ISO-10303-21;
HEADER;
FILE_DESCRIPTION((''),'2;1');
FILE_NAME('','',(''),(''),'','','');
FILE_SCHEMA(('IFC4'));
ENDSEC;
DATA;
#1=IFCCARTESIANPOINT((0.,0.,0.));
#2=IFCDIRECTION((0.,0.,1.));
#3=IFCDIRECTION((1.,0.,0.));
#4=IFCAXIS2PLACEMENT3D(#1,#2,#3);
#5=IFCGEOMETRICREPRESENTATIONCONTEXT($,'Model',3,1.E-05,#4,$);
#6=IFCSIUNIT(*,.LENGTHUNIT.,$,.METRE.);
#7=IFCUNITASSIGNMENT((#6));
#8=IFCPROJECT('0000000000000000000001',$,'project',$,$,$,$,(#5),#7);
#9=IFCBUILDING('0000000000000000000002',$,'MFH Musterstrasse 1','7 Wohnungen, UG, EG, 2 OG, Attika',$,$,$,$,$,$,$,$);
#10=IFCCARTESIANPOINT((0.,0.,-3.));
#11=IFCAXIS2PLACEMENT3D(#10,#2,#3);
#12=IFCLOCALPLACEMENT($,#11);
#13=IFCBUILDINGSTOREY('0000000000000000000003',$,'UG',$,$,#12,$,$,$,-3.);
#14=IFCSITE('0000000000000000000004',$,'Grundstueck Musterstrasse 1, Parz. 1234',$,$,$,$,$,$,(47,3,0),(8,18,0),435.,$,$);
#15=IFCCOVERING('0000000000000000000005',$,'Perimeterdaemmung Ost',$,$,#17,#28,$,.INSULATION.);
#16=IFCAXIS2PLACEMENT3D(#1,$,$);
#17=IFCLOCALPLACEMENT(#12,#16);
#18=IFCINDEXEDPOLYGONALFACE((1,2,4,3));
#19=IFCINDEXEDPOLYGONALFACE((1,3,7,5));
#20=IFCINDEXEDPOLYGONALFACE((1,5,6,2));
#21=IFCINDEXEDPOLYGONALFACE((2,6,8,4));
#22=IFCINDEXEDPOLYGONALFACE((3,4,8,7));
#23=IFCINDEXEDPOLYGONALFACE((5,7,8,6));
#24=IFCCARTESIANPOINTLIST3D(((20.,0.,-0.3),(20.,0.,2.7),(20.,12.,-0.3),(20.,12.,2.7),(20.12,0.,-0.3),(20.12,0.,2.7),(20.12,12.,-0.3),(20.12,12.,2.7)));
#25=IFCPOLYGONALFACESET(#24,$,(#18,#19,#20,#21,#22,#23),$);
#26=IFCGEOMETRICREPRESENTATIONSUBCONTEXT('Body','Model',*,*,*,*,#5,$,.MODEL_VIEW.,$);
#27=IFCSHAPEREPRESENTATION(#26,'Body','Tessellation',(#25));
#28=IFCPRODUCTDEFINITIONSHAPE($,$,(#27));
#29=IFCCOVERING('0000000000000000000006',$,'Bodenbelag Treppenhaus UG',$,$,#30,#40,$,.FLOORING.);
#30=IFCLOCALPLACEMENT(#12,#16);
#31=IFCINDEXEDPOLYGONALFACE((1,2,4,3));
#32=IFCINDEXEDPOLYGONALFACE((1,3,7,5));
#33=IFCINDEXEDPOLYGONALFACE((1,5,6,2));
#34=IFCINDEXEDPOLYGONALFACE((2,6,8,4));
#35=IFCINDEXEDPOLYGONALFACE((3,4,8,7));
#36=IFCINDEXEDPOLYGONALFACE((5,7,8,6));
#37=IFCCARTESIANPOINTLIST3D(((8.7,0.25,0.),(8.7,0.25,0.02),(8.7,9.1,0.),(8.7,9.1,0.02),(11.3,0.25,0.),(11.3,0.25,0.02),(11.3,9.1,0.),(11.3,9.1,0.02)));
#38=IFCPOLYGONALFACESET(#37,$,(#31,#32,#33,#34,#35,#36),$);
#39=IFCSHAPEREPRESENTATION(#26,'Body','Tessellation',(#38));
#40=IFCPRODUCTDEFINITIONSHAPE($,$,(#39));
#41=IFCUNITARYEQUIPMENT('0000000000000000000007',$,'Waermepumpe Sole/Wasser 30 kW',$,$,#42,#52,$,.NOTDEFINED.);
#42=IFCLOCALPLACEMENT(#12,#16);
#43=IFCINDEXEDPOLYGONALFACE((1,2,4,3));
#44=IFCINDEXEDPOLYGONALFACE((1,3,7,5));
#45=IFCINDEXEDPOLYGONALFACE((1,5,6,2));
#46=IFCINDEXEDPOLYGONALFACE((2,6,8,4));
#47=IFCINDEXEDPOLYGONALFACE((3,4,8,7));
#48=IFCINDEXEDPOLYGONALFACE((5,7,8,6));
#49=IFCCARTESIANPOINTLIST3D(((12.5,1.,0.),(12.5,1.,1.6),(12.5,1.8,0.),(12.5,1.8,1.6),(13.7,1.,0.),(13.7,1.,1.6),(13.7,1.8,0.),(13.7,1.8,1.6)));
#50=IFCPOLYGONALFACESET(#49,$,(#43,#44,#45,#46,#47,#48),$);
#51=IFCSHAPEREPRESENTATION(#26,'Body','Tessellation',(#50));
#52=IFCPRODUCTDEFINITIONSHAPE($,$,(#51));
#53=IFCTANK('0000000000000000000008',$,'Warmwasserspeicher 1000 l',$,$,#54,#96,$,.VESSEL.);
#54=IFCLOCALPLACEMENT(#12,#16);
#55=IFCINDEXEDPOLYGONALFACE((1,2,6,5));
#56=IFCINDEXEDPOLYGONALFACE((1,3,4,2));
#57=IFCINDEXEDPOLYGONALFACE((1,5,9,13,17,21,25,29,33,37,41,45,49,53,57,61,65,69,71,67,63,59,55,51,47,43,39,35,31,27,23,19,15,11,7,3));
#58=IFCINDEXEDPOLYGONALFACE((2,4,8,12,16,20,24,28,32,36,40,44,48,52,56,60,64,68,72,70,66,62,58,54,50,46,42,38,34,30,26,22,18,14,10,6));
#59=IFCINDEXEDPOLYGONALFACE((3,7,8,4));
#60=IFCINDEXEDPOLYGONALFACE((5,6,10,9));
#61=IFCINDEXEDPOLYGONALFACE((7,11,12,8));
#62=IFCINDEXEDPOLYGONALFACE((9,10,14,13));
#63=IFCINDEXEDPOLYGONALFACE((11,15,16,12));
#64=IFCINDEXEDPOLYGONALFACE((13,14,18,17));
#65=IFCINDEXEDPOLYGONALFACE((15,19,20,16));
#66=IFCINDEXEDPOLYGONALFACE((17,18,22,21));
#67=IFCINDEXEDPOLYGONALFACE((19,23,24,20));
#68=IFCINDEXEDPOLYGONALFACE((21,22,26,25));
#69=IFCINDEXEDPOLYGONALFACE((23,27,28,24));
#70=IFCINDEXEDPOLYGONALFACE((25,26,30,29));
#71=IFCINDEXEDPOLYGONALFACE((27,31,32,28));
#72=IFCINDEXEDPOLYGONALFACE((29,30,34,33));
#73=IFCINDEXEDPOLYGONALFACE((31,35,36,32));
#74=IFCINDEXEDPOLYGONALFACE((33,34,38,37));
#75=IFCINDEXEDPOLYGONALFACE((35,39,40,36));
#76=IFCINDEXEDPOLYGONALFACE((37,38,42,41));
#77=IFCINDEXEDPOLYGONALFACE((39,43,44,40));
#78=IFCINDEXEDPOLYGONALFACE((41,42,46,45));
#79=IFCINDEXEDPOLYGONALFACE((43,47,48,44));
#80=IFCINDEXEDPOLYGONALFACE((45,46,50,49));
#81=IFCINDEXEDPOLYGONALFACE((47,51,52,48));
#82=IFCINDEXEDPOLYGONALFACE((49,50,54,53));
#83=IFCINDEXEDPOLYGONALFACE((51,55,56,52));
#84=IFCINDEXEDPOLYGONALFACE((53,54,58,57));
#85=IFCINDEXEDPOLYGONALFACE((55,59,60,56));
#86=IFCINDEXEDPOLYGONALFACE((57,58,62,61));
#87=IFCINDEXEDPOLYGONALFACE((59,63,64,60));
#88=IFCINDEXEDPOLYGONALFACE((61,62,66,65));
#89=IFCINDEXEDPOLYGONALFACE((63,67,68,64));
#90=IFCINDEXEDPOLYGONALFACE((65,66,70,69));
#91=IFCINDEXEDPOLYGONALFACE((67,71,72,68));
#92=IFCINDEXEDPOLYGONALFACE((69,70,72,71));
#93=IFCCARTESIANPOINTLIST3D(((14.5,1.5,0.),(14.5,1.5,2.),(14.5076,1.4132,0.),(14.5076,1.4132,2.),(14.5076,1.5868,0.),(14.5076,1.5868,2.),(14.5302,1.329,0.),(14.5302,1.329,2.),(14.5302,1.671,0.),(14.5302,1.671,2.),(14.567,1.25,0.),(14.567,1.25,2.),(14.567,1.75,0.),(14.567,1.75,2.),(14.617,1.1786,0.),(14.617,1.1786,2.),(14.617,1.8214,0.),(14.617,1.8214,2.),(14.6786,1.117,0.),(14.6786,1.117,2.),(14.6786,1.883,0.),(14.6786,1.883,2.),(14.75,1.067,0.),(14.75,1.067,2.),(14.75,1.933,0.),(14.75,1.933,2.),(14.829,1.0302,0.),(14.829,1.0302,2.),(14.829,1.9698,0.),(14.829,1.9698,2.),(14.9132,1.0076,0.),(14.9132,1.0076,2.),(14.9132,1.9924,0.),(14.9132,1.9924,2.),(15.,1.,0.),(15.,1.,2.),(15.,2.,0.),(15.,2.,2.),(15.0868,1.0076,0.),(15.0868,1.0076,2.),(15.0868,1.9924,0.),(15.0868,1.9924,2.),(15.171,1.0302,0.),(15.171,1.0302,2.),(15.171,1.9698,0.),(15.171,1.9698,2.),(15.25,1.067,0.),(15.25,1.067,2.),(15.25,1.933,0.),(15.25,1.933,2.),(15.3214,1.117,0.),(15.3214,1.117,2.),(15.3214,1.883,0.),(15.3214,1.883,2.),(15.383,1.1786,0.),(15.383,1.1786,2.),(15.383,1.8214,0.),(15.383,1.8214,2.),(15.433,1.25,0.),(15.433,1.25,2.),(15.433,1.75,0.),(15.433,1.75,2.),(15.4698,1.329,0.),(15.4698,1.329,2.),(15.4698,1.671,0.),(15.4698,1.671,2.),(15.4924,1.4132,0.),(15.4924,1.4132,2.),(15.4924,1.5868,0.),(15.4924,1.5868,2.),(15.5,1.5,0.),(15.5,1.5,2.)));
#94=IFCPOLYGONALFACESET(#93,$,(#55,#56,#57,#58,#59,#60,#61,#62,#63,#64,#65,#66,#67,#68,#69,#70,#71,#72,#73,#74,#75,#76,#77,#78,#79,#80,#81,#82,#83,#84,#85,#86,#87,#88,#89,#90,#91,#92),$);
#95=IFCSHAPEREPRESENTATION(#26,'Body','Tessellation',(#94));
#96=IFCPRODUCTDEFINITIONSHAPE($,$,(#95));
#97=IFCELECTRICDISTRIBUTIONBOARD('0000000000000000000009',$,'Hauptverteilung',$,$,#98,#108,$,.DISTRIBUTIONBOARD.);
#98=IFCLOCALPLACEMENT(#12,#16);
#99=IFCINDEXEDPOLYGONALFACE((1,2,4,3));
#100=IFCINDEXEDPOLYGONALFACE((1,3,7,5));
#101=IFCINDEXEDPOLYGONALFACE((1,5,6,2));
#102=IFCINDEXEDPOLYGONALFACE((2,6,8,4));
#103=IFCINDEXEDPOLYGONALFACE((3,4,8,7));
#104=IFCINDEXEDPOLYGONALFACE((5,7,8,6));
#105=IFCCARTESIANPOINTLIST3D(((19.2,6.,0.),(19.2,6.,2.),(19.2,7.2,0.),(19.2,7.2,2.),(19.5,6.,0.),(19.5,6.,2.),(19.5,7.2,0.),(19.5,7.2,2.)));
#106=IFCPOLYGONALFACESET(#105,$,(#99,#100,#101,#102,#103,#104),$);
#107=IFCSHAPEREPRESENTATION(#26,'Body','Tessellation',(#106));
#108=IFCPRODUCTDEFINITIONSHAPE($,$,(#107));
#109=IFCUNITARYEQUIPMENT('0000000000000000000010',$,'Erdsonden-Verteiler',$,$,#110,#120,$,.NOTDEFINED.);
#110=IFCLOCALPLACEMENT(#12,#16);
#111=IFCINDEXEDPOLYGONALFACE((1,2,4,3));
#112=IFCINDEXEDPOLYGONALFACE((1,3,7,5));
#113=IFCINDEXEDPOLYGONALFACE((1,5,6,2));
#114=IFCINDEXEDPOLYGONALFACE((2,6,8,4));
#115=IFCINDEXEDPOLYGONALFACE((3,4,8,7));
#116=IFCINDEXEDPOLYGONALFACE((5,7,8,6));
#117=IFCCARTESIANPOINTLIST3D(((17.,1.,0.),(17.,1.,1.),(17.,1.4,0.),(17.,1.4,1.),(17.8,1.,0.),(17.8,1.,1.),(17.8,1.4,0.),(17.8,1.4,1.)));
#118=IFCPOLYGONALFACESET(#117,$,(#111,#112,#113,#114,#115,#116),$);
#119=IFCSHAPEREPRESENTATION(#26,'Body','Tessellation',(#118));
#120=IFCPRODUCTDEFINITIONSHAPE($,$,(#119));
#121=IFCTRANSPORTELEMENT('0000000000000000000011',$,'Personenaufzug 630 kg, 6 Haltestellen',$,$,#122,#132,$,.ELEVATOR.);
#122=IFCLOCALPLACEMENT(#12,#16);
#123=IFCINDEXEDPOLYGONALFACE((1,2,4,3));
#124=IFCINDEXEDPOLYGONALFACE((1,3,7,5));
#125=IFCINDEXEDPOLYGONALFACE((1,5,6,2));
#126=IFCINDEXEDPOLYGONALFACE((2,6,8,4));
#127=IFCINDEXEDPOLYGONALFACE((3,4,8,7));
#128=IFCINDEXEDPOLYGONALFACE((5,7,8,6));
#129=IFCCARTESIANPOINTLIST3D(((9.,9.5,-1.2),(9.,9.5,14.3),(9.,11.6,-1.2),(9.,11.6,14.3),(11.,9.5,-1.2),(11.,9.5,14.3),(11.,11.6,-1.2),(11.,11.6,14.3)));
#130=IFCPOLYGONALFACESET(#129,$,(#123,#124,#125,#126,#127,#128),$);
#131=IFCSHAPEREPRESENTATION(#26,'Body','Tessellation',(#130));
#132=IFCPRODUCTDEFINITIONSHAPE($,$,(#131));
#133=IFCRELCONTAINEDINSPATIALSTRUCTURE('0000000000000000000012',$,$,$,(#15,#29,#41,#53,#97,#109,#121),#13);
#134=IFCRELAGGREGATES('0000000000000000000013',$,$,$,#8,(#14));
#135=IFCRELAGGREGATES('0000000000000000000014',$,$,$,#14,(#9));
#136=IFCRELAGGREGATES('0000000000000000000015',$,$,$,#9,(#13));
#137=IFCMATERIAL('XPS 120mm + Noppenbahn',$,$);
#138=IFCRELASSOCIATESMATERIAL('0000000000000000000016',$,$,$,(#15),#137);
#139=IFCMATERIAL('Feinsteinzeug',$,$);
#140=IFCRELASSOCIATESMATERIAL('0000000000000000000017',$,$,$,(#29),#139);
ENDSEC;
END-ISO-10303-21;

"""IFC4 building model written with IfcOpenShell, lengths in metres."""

from ifc_helpers import new_model, si_unit, frame, frame_2d, origin_with_axes, origin_2d, place, context, subcontext, project, spatial, rectangle, circle, extrude, material, element, save


model = new_model("IFC4")

# Units and contexts
model_context = context("Model", 3, precision=1e-05, world=origin_with_axes())
body_context = subcontext(model_context, "Body", "Model", "MODEL_VIEW")
ifc_project = project(units=[si_unit("LENGTHUNIT", "METRE")], contexts=[model_context])

# Site, building, storey
site = spatial("IfcSite", under=ifc_project, Name="Grundstueck Musterstrasse 1, Parz. 1234", RefLatitude=(47, 3, 0), RefLongitude=(8, 18, 0), RefElevation=435.0)
building = spatial("IfcBuilding", under=site, Name="MFH Musterstrasse 1", Description="7 Wohnungen, UG, EG, 2 OG, Attika")
storey_placement = place(None, frame((0.0, 0.0, -3.0), z_axis=(0.0, 0.0, 1.0), x_axis=(1.0, 0.0, 0.0)))
storey = spatial("IfcBuildingStorey", under=building, at=storey_placement, Name="UG", Elevation=-3.0)

# Coverings
ifc_material_1 = material(Name="XPS 120mm + Noppenbahn")
for number, where, z_axis, x_axis, name in (
    (1, (20.0, 0.0, -0.3), (0.0, 0.0, 1.0), (1.0, 0.0, 0.0), "Perimeterdaemmung Ost"),
):
    element("IfcCovering", number, at=place(storey_placement, frame(where, z_axis=z_axis, x_axis=x_axis)), inside=storey, material=ifc_material_1, Name=name, PredefinedType="INSULATION", context=body_context, shape_type="SweptSolid", body=[
        extrude(rectangle(XDim=0.12, YDim=12.0, at=frame_2d((0.06, 6.0))), origin_with_axes(), (0.0, 0.0, 1.0), 3.0),
    ])
ifc_material_2 = material(Name="Feinsteinzeug")
covering_placement = place(storey_placement, frame((8.7, 0.25, 0.0), z_axis=(0.0, 0.0, 1.0), x_axis=(1.0, 0.0, 0.0)))
element("IfcCovering", 2, at=covering_placement, inside=storey, material=ifc_material_2, Name="Bodenbelag Treppenhaus UG", PredefinedType="FLOORING", context=body_context, shape_type="SweptSolid", body=[
    extrude(rectangle(XDim=2.6, YDim=8.85, at=frame_2d((1.3, 4.425))), origin_with_axes(), (0.0, 0.0, 1.0), 0.02),
])

# Unitary equipment
unitary_equipment_1_placement = place(storey_placement, frame((12.5, 1.0, 0.0), z_axis=(0.0, 0.0, 1.0), x_axis=(1.0, 0.0, 0.0)))
element("IfcUnitaryEquipment", 3, at=unitary_equipment_1_placement, inside=storey, Name="Waermepumpe Sole/Wasser 30 kW", PredefinedType="NOTDEFINED", context=body_context, shape_type="SweptSolid", body=[
    extrude(rectangle(XDim=1.2, YDim=0.8, at=frame_2d((0.6, 0.4))), origin_with_axes(), (0.0, 0.0, 1.0), 1.6),
])

# Tank
tank_placement = place(storey_placement, frame((15.0, 1.5, 0.0), z_axis=(0.0, 0.0, 1.0), x_axis=(1.0, 0.0, 0.0)))
element("IfcTank", 4, at=tank_placement, inside=storey, Name="Warmwasserspeicher 1000 l", PredefinedType="VESSEL", context=body_context, shape_type="SweptSolid", body=[
    extrude(circle(Radius=0.5, at=origin_2d()), origin_with_axes(), (0.0, 0.0, 1.0), 2.0),
])

# Electric distribution board
electric_distribution_board_placement = place(storey_placement, frame((19.2, 6.0, 0.0), z_axis=(0.0, 0.0, 1.0), x_axis=(1.0, 0.0, 0.0)))
element("IfcElectricDistributionBoard", 5, at=electric_distribution_board_placement, inside=storey, Name="Hauptverteilung", PredefinedType="DISTRIBUTIONBOARD", context=body_context, shape_type="SweptSolid", body=[
    extrude(rectangle(XDim=0.3, YDim=1.2, at=frame_2d((0.15, 0.6))), origin_with_axes(), (0.0, 0.0, 1.0), 2.0),
])

# Unitary equipment
unitary_equipment_2_placement = place(storey_placement, frame((17.0, 1.0, 0.0), z_axis=(0.0, 0.0, 1.0), x_axis=(1.0, 0.0, 0.0)))
element("IfcUnitaryEquipment", 6, at=unitary_equipment_2_placement, inside=storey, Name="Erdsonden-Verteiler", PredefinedType="NOTDEFINED", context=body_context, shape_type="SweptSolid", body=[
    extrude(rectangle(XDim=0.8, YDim=0.4, at=frame_2d((0.4, 0.2))), origin_with_axes(), (0.0, 0.0, 1.0), 1.0),
])

# Transport element
transport_element_placement = place(storey_placement, frame((9.0, 9.5, -1.2), z_axis=(0.0, 0.0, 1.0), x_axis=(1.0, 0.0, 0.0)))
element("IfcTransportElement", 7, at=transport_element_placement, inside=storey, Name="Personenaufzug 630 kg, 6 Haltestellen", PredefinedType="ELEVATOR", context=body_context, shape_type="SweptSolid", body=[
    extrude(rectangle(XDim=2.0, YDim=2.1, at=frame_2d((1.0, 1.05))), origin_with_axes(), (0.0, 0.0, 1.0), 15.5),
])

save(model, "model.ifc")
